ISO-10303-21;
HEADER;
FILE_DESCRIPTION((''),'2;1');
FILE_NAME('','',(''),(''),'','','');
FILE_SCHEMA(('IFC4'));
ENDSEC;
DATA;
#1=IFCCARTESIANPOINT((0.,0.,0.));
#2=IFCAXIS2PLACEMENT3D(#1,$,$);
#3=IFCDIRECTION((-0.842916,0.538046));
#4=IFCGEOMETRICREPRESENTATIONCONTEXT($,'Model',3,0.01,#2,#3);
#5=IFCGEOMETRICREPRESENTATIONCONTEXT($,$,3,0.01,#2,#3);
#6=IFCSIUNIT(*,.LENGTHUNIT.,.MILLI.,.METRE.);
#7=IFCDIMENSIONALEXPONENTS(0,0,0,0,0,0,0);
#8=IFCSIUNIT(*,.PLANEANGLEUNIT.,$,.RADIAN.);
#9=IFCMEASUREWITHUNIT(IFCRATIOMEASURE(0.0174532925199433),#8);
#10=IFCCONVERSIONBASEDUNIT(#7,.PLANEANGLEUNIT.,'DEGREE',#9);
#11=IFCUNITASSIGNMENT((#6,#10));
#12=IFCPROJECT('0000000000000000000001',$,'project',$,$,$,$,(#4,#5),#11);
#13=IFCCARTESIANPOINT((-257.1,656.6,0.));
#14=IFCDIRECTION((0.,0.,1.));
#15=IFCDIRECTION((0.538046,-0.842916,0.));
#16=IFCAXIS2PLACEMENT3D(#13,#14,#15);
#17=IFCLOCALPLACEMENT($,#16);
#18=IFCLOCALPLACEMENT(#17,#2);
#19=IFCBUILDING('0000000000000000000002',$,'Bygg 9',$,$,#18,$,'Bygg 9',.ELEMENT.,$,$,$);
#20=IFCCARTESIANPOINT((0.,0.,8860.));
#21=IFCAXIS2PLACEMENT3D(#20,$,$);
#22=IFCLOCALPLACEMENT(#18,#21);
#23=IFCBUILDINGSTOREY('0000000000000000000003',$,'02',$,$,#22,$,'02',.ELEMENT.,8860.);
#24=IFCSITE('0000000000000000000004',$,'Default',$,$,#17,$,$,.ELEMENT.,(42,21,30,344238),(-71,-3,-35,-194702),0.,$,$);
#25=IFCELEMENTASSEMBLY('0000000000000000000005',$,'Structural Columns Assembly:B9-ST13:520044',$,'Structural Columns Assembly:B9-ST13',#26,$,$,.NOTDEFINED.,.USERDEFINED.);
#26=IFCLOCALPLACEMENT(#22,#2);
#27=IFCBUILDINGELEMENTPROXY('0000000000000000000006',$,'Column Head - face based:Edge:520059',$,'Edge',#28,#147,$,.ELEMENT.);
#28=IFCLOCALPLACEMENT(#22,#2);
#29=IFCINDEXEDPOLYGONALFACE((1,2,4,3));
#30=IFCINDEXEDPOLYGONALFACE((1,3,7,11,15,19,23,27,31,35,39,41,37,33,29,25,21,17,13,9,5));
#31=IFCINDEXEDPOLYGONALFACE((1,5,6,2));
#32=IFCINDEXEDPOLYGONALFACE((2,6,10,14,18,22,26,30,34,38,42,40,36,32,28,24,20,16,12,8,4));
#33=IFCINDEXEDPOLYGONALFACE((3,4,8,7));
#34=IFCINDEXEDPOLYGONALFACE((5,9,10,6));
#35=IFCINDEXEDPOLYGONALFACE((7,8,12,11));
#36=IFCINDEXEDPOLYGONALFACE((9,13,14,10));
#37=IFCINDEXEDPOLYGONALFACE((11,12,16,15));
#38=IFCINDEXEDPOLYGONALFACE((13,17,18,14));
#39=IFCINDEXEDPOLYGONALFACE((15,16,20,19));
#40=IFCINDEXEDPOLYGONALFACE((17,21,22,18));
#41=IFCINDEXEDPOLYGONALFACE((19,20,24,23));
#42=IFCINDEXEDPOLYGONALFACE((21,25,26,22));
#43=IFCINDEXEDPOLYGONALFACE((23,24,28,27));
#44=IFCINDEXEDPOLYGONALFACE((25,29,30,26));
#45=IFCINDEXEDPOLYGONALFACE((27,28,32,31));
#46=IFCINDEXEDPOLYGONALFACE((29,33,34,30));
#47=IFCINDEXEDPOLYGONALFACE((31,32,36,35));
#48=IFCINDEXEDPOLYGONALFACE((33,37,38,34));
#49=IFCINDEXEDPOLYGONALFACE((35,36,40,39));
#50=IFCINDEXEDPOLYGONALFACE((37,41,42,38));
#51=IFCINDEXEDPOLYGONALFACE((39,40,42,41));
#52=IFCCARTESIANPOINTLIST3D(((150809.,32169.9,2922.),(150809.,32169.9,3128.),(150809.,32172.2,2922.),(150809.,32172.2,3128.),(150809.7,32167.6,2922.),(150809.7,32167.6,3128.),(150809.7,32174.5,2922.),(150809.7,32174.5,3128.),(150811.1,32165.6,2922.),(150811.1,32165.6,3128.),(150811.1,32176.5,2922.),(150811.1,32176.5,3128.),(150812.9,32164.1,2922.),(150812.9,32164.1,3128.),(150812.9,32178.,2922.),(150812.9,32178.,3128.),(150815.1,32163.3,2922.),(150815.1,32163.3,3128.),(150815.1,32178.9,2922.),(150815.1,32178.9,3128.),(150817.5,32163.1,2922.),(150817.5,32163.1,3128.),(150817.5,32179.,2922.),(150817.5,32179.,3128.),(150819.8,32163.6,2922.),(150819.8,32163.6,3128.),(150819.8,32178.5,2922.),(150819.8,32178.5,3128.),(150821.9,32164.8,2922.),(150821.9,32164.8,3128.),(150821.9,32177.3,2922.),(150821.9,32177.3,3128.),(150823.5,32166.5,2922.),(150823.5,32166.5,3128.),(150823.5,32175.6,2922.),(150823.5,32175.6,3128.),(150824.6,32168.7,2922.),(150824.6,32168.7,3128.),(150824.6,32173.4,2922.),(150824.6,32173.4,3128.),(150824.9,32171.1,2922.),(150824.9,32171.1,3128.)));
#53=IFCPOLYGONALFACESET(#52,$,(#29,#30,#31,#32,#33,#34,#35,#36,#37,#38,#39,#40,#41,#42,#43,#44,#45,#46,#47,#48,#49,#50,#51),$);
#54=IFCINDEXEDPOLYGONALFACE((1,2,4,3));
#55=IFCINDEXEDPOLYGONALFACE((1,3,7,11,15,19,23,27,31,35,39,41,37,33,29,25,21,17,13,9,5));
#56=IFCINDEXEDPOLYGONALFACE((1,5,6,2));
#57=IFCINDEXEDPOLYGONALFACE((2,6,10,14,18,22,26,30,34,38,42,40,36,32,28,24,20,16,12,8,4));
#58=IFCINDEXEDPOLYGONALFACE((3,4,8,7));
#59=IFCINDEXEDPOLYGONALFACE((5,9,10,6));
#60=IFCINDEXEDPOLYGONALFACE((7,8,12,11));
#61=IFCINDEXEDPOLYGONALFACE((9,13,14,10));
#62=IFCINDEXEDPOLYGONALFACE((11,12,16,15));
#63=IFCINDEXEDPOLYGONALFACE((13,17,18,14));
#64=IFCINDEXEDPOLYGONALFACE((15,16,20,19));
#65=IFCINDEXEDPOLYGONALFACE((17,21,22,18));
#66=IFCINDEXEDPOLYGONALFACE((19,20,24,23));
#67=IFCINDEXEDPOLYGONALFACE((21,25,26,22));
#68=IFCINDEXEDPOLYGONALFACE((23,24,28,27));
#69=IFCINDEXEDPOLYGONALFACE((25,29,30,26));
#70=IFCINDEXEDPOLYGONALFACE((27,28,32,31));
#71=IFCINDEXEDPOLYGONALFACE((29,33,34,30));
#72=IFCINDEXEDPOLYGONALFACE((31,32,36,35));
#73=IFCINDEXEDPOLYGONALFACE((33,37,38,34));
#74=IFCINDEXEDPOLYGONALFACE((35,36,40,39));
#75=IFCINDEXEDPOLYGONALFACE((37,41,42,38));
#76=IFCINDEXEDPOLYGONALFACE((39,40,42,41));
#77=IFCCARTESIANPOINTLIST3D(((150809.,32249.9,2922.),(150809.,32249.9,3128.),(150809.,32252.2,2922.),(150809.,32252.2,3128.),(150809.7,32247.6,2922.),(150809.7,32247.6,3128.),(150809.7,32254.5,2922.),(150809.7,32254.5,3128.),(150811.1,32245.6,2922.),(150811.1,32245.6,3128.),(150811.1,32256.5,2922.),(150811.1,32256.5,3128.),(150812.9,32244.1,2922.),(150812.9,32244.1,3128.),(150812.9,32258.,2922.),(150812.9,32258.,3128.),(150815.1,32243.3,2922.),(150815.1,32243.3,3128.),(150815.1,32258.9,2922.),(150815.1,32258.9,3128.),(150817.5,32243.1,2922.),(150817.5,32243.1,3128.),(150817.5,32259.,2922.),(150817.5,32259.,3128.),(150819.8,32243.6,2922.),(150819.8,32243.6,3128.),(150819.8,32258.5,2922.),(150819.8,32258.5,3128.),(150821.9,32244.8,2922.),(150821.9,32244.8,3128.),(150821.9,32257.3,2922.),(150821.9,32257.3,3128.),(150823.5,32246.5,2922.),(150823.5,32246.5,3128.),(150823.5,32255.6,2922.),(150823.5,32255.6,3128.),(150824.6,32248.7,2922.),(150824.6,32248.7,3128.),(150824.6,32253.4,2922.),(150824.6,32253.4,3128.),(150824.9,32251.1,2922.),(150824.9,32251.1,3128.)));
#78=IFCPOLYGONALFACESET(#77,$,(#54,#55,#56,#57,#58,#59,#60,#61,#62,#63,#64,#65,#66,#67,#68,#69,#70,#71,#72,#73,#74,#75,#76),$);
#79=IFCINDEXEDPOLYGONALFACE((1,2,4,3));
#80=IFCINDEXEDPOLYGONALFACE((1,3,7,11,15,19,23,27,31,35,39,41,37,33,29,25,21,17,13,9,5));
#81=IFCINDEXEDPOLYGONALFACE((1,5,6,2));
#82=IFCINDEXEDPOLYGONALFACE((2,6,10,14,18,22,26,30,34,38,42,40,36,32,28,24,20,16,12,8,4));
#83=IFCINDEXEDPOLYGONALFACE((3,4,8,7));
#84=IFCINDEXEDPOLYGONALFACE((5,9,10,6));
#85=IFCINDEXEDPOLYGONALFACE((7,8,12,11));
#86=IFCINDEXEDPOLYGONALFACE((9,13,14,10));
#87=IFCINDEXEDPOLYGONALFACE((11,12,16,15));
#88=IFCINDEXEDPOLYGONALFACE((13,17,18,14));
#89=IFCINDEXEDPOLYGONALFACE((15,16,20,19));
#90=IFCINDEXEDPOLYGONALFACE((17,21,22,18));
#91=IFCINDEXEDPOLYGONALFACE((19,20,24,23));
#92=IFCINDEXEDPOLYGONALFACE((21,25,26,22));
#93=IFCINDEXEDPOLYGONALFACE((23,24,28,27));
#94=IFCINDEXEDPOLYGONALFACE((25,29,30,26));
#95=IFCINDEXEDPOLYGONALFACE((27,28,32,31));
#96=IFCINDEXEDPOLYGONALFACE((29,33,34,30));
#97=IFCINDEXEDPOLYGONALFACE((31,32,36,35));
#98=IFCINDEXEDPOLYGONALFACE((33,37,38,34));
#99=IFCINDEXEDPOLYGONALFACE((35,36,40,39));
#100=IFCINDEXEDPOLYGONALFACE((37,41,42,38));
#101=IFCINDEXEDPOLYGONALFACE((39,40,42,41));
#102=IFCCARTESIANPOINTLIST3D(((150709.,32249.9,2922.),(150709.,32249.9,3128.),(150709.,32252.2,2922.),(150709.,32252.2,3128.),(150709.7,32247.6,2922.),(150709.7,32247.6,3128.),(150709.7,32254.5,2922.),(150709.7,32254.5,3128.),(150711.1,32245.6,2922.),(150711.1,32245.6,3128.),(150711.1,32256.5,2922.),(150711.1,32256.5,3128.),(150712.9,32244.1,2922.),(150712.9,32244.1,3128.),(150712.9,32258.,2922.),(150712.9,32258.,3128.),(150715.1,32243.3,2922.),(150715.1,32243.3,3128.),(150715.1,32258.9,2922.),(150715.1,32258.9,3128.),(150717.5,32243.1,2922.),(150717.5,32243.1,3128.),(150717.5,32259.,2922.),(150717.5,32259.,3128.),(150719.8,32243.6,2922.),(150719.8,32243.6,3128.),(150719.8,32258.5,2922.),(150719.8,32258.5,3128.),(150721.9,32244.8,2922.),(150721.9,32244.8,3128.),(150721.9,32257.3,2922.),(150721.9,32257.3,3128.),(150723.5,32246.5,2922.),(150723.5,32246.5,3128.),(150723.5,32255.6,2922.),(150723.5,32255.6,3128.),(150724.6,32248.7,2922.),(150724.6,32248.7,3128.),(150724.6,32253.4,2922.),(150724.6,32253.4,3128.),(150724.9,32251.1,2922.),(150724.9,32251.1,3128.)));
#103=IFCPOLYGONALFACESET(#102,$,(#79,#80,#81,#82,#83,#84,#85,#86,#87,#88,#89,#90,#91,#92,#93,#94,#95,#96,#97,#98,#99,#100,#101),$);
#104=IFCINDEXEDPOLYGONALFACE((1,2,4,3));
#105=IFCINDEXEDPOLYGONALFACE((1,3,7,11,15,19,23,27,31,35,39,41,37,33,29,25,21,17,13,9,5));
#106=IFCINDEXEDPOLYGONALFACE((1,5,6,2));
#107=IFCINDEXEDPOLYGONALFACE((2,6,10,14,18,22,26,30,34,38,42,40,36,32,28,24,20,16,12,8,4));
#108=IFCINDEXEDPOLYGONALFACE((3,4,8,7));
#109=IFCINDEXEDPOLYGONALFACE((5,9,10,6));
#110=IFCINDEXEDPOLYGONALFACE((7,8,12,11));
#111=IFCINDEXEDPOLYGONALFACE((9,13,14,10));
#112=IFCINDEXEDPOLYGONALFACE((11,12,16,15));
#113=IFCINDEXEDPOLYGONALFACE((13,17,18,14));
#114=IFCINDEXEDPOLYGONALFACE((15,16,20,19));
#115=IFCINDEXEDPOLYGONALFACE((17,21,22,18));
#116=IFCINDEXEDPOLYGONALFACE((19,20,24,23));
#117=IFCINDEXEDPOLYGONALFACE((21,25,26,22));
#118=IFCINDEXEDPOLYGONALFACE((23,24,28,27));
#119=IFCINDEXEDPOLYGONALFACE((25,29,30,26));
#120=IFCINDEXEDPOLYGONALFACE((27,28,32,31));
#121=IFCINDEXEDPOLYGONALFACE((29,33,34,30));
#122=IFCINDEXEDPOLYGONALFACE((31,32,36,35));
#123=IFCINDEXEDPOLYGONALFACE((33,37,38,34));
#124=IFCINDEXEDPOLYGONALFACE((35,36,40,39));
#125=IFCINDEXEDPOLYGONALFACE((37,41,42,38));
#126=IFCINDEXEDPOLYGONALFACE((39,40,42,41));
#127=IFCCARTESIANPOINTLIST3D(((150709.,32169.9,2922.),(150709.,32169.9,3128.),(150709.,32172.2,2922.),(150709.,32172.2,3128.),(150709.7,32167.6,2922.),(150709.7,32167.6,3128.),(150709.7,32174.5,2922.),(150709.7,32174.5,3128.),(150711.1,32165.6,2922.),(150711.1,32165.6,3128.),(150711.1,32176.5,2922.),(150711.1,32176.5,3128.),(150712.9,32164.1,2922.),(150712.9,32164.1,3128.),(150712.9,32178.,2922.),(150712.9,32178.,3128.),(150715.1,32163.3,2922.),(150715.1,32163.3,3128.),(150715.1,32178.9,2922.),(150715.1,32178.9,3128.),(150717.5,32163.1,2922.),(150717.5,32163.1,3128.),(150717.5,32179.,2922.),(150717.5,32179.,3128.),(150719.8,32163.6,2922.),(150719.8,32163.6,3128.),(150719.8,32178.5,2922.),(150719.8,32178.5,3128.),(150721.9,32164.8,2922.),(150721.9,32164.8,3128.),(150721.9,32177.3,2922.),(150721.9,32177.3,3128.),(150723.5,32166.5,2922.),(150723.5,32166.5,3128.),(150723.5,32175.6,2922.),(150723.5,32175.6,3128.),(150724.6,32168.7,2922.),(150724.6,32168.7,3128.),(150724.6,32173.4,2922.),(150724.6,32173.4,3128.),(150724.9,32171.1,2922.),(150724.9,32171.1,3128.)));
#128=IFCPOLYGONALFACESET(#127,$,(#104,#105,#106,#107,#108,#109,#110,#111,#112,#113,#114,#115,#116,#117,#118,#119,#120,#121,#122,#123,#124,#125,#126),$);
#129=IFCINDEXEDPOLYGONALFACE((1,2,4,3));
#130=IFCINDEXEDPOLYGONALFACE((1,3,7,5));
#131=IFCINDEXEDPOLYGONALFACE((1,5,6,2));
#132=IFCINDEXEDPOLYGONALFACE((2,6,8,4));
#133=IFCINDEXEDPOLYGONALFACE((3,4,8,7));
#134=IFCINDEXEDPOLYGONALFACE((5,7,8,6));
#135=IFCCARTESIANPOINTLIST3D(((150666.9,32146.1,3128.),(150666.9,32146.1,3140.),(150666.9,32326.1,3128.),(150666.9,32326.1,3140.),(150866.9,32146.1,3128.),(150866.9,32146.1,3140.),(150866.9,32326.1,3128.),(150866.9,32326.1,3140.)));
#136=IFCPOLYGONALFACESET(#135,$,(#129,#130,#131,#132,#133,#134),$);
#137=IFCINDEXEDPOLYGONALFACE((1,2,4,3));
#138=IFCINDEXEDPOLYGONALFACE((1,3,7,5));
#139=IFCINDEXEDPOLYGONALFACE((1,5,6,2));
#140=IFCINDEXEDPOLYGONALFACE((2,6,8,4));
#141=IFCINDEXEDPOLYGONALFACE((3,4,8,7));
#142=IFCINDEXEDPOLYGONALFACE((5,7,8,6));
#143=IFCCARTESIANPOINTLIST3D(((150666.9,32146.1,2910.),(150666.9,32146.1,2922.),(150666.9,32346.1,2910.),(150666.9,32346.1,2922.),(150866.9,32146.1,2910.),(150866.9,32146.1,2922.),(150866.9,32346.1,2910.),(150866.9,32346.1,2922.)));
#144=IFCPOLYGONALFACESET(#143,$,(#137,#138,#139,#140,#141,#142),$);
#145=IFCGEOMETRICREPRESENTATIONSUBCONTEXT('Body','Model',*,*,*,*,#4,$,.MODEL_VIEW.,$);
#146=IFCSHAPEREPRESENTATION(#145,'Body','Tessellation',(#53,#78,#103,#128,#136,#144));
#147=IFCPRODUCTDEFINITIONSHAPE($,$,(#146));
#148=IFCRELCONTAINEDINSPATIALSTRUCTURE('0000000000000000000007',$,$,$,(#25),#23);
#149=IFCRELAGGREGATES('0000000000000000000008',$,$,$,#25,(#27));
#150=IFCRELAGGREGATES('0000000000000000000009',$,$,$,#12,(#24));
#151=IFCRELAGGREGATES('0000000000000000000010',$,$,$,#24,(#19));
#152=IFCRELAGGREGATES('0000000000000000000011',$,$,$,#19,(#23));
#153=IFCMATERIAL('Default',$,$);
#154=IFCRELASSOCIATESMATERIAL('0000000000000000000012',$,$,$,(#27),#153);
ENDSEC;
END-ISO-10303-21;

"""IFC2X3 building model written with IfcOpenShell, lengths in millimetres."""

from ifc_helpers import new_model, entity, si_unit, converted_unit, direction, frame, frame_2d, origin, origin_2d_with_axis, place, context, subcontext, project, spatial, rectangle, circle, extrude, source, transform, mapped, material, element, aggregate, save


model = new_model("IFC2X3")

# Units and contexts
model_context = context("Model", 3, precision=0.01, world=origin(), true_north=direction((-0.842916, 0.538046)))
context_of_model = context(None, 3, precision=0.01, world=origin(), true_north=direction((-0.842916, 0.538046)))
body_context = subcontext(model_context, "Body", "Model", "MODEL_VIEW")
ifc_project = project(units=[si_unit("LENGTHUNIT", "METRE", prefix="MILLI"), converted_unit("PLANEANGLEUNIT", "DEGREE", entity("IfcRatioMeasure", 0.0174532925199433), si_unit("PLANEANGLEUNIT", "RADIAN"), dimensions=[0, 0, 0, 0, 0, 0, 0])], contexts=[model_context, context_of_model])

# Site, building, storey
site_placement = place(None, frame((-257.1, 656.6, 0.0), z_axis=(0.0, 0.0, 1.0), x_axis=(0.538046, -0.842916, 0.0)))
site = spatial("IfcSite", under=ifc_project, at=site_placement, Name="Default", CompositionType="ELEMENT", RefLatitude=(42, 21, 30, 344238), RefLongitude=(-71, -3, -35, -194702), RefElevation=0.0)
building_placement = place(site_placement, origin())
building = spatial("IfcBuilding", under=site, at=building_placement, Name="Bygg 9", LongName="Bygg 9", CompositionType="ELEMENT")
storey_placement = place(building_placement, frame((0.0, 0.0, 8860.0)))
storey = spatial("IfcBuildingStorey", under=building, at=storey_placement, Name="02", LongName="02", CompositionType="ELEMENT", Elevation=8860.0)

# Shared definitions
ifc_material_1 = material(Name="Default")

# Element assembly, building element proxy
shared_shape_1 = source(origin(), body_context, "Body", "SweptSolid", [
    extrude(circle(Radius=8.0, at=frame_2d((0.0, 0.0), x_axis=(1.0, 0.0))), frame((50.0, -135.0, 12.0)), (0.0, 0.0, 1.0), 206.0),
    extrude(circle(Radius=8.0, at=frame_2d((0.0, 0.0), x_axis=(1.0, 0.0))), frame((50.0, -55.0, 12.0)), (0.0, 0.0, 1.0), 206.0),
    extrude(circle(Radius=8.0, at=frame_2d((0.0, 0.0), x_axis=(1.0, 0.0))), frame((-50.0, -55.0, 12.0)), (0.0, 0.0, 1.0), 206.0),
    extrude(circle(Radius=8.0, at=frame_2d((0.0, 0.0), x_axis=(1.0, 0.0))), frame((-50.0, -135.0, 12.0)), (0.0, 0.0, 1.0), 206.0),
    extrude(rectangle(XDim=200.0, YDim=180.0, at=origin_2d_with_axis()), frame((0.0, -70.0, 218.0), z_axis=(0.0, 0.0, 1.0), x_axis=(-1.0, 0.0, 0.0)), (0.0, 0.0, 1.0), 12.0),
    extrude(rectangle(XDim=200.0, YDim=200.0, at=origin_2d_with_axis()), frame((0.0, -60.0, 0.0), z_axis=(0.0, 0.0, 1.0), x_axis=(0.0, 1.0, 0.0)), (0.0, 0.0, 1.0), 12.0),
])
assembly_1_placement = place(storey_placement, origin())
assembly_1 = element("IfcElementAssembly", 1, at=assembly_1_placement, inside=storey, Name="Structural Columns Assembly:B9-ST13:520044", ObjectType="Structural Columns Assembly:B9-ST13", AssemblyPlace="NOTDEFINED", PredefinedType="USERDEFINED")
proxy_1_placement = place(assembly_1_placement, frame((150766.9, 32306.1, 2910.0)))
proxy_1 = element("IfcBuildingElementProxy", 2, at=proxy_1_placement, material=ifc_material_1, Name="Column Head - face based:Edge:520059", ObjectType="Edge", CompositionType="ELEMENT", context=body_context, shape_type="MappedRepresentation", body=[
    mapped(shared_shape_1, transform((0.0, 0.0, 0.0), scale=1.0)),
])
aggregate(assembly_1, [proxy_1])

save(model, "model.ifc")
